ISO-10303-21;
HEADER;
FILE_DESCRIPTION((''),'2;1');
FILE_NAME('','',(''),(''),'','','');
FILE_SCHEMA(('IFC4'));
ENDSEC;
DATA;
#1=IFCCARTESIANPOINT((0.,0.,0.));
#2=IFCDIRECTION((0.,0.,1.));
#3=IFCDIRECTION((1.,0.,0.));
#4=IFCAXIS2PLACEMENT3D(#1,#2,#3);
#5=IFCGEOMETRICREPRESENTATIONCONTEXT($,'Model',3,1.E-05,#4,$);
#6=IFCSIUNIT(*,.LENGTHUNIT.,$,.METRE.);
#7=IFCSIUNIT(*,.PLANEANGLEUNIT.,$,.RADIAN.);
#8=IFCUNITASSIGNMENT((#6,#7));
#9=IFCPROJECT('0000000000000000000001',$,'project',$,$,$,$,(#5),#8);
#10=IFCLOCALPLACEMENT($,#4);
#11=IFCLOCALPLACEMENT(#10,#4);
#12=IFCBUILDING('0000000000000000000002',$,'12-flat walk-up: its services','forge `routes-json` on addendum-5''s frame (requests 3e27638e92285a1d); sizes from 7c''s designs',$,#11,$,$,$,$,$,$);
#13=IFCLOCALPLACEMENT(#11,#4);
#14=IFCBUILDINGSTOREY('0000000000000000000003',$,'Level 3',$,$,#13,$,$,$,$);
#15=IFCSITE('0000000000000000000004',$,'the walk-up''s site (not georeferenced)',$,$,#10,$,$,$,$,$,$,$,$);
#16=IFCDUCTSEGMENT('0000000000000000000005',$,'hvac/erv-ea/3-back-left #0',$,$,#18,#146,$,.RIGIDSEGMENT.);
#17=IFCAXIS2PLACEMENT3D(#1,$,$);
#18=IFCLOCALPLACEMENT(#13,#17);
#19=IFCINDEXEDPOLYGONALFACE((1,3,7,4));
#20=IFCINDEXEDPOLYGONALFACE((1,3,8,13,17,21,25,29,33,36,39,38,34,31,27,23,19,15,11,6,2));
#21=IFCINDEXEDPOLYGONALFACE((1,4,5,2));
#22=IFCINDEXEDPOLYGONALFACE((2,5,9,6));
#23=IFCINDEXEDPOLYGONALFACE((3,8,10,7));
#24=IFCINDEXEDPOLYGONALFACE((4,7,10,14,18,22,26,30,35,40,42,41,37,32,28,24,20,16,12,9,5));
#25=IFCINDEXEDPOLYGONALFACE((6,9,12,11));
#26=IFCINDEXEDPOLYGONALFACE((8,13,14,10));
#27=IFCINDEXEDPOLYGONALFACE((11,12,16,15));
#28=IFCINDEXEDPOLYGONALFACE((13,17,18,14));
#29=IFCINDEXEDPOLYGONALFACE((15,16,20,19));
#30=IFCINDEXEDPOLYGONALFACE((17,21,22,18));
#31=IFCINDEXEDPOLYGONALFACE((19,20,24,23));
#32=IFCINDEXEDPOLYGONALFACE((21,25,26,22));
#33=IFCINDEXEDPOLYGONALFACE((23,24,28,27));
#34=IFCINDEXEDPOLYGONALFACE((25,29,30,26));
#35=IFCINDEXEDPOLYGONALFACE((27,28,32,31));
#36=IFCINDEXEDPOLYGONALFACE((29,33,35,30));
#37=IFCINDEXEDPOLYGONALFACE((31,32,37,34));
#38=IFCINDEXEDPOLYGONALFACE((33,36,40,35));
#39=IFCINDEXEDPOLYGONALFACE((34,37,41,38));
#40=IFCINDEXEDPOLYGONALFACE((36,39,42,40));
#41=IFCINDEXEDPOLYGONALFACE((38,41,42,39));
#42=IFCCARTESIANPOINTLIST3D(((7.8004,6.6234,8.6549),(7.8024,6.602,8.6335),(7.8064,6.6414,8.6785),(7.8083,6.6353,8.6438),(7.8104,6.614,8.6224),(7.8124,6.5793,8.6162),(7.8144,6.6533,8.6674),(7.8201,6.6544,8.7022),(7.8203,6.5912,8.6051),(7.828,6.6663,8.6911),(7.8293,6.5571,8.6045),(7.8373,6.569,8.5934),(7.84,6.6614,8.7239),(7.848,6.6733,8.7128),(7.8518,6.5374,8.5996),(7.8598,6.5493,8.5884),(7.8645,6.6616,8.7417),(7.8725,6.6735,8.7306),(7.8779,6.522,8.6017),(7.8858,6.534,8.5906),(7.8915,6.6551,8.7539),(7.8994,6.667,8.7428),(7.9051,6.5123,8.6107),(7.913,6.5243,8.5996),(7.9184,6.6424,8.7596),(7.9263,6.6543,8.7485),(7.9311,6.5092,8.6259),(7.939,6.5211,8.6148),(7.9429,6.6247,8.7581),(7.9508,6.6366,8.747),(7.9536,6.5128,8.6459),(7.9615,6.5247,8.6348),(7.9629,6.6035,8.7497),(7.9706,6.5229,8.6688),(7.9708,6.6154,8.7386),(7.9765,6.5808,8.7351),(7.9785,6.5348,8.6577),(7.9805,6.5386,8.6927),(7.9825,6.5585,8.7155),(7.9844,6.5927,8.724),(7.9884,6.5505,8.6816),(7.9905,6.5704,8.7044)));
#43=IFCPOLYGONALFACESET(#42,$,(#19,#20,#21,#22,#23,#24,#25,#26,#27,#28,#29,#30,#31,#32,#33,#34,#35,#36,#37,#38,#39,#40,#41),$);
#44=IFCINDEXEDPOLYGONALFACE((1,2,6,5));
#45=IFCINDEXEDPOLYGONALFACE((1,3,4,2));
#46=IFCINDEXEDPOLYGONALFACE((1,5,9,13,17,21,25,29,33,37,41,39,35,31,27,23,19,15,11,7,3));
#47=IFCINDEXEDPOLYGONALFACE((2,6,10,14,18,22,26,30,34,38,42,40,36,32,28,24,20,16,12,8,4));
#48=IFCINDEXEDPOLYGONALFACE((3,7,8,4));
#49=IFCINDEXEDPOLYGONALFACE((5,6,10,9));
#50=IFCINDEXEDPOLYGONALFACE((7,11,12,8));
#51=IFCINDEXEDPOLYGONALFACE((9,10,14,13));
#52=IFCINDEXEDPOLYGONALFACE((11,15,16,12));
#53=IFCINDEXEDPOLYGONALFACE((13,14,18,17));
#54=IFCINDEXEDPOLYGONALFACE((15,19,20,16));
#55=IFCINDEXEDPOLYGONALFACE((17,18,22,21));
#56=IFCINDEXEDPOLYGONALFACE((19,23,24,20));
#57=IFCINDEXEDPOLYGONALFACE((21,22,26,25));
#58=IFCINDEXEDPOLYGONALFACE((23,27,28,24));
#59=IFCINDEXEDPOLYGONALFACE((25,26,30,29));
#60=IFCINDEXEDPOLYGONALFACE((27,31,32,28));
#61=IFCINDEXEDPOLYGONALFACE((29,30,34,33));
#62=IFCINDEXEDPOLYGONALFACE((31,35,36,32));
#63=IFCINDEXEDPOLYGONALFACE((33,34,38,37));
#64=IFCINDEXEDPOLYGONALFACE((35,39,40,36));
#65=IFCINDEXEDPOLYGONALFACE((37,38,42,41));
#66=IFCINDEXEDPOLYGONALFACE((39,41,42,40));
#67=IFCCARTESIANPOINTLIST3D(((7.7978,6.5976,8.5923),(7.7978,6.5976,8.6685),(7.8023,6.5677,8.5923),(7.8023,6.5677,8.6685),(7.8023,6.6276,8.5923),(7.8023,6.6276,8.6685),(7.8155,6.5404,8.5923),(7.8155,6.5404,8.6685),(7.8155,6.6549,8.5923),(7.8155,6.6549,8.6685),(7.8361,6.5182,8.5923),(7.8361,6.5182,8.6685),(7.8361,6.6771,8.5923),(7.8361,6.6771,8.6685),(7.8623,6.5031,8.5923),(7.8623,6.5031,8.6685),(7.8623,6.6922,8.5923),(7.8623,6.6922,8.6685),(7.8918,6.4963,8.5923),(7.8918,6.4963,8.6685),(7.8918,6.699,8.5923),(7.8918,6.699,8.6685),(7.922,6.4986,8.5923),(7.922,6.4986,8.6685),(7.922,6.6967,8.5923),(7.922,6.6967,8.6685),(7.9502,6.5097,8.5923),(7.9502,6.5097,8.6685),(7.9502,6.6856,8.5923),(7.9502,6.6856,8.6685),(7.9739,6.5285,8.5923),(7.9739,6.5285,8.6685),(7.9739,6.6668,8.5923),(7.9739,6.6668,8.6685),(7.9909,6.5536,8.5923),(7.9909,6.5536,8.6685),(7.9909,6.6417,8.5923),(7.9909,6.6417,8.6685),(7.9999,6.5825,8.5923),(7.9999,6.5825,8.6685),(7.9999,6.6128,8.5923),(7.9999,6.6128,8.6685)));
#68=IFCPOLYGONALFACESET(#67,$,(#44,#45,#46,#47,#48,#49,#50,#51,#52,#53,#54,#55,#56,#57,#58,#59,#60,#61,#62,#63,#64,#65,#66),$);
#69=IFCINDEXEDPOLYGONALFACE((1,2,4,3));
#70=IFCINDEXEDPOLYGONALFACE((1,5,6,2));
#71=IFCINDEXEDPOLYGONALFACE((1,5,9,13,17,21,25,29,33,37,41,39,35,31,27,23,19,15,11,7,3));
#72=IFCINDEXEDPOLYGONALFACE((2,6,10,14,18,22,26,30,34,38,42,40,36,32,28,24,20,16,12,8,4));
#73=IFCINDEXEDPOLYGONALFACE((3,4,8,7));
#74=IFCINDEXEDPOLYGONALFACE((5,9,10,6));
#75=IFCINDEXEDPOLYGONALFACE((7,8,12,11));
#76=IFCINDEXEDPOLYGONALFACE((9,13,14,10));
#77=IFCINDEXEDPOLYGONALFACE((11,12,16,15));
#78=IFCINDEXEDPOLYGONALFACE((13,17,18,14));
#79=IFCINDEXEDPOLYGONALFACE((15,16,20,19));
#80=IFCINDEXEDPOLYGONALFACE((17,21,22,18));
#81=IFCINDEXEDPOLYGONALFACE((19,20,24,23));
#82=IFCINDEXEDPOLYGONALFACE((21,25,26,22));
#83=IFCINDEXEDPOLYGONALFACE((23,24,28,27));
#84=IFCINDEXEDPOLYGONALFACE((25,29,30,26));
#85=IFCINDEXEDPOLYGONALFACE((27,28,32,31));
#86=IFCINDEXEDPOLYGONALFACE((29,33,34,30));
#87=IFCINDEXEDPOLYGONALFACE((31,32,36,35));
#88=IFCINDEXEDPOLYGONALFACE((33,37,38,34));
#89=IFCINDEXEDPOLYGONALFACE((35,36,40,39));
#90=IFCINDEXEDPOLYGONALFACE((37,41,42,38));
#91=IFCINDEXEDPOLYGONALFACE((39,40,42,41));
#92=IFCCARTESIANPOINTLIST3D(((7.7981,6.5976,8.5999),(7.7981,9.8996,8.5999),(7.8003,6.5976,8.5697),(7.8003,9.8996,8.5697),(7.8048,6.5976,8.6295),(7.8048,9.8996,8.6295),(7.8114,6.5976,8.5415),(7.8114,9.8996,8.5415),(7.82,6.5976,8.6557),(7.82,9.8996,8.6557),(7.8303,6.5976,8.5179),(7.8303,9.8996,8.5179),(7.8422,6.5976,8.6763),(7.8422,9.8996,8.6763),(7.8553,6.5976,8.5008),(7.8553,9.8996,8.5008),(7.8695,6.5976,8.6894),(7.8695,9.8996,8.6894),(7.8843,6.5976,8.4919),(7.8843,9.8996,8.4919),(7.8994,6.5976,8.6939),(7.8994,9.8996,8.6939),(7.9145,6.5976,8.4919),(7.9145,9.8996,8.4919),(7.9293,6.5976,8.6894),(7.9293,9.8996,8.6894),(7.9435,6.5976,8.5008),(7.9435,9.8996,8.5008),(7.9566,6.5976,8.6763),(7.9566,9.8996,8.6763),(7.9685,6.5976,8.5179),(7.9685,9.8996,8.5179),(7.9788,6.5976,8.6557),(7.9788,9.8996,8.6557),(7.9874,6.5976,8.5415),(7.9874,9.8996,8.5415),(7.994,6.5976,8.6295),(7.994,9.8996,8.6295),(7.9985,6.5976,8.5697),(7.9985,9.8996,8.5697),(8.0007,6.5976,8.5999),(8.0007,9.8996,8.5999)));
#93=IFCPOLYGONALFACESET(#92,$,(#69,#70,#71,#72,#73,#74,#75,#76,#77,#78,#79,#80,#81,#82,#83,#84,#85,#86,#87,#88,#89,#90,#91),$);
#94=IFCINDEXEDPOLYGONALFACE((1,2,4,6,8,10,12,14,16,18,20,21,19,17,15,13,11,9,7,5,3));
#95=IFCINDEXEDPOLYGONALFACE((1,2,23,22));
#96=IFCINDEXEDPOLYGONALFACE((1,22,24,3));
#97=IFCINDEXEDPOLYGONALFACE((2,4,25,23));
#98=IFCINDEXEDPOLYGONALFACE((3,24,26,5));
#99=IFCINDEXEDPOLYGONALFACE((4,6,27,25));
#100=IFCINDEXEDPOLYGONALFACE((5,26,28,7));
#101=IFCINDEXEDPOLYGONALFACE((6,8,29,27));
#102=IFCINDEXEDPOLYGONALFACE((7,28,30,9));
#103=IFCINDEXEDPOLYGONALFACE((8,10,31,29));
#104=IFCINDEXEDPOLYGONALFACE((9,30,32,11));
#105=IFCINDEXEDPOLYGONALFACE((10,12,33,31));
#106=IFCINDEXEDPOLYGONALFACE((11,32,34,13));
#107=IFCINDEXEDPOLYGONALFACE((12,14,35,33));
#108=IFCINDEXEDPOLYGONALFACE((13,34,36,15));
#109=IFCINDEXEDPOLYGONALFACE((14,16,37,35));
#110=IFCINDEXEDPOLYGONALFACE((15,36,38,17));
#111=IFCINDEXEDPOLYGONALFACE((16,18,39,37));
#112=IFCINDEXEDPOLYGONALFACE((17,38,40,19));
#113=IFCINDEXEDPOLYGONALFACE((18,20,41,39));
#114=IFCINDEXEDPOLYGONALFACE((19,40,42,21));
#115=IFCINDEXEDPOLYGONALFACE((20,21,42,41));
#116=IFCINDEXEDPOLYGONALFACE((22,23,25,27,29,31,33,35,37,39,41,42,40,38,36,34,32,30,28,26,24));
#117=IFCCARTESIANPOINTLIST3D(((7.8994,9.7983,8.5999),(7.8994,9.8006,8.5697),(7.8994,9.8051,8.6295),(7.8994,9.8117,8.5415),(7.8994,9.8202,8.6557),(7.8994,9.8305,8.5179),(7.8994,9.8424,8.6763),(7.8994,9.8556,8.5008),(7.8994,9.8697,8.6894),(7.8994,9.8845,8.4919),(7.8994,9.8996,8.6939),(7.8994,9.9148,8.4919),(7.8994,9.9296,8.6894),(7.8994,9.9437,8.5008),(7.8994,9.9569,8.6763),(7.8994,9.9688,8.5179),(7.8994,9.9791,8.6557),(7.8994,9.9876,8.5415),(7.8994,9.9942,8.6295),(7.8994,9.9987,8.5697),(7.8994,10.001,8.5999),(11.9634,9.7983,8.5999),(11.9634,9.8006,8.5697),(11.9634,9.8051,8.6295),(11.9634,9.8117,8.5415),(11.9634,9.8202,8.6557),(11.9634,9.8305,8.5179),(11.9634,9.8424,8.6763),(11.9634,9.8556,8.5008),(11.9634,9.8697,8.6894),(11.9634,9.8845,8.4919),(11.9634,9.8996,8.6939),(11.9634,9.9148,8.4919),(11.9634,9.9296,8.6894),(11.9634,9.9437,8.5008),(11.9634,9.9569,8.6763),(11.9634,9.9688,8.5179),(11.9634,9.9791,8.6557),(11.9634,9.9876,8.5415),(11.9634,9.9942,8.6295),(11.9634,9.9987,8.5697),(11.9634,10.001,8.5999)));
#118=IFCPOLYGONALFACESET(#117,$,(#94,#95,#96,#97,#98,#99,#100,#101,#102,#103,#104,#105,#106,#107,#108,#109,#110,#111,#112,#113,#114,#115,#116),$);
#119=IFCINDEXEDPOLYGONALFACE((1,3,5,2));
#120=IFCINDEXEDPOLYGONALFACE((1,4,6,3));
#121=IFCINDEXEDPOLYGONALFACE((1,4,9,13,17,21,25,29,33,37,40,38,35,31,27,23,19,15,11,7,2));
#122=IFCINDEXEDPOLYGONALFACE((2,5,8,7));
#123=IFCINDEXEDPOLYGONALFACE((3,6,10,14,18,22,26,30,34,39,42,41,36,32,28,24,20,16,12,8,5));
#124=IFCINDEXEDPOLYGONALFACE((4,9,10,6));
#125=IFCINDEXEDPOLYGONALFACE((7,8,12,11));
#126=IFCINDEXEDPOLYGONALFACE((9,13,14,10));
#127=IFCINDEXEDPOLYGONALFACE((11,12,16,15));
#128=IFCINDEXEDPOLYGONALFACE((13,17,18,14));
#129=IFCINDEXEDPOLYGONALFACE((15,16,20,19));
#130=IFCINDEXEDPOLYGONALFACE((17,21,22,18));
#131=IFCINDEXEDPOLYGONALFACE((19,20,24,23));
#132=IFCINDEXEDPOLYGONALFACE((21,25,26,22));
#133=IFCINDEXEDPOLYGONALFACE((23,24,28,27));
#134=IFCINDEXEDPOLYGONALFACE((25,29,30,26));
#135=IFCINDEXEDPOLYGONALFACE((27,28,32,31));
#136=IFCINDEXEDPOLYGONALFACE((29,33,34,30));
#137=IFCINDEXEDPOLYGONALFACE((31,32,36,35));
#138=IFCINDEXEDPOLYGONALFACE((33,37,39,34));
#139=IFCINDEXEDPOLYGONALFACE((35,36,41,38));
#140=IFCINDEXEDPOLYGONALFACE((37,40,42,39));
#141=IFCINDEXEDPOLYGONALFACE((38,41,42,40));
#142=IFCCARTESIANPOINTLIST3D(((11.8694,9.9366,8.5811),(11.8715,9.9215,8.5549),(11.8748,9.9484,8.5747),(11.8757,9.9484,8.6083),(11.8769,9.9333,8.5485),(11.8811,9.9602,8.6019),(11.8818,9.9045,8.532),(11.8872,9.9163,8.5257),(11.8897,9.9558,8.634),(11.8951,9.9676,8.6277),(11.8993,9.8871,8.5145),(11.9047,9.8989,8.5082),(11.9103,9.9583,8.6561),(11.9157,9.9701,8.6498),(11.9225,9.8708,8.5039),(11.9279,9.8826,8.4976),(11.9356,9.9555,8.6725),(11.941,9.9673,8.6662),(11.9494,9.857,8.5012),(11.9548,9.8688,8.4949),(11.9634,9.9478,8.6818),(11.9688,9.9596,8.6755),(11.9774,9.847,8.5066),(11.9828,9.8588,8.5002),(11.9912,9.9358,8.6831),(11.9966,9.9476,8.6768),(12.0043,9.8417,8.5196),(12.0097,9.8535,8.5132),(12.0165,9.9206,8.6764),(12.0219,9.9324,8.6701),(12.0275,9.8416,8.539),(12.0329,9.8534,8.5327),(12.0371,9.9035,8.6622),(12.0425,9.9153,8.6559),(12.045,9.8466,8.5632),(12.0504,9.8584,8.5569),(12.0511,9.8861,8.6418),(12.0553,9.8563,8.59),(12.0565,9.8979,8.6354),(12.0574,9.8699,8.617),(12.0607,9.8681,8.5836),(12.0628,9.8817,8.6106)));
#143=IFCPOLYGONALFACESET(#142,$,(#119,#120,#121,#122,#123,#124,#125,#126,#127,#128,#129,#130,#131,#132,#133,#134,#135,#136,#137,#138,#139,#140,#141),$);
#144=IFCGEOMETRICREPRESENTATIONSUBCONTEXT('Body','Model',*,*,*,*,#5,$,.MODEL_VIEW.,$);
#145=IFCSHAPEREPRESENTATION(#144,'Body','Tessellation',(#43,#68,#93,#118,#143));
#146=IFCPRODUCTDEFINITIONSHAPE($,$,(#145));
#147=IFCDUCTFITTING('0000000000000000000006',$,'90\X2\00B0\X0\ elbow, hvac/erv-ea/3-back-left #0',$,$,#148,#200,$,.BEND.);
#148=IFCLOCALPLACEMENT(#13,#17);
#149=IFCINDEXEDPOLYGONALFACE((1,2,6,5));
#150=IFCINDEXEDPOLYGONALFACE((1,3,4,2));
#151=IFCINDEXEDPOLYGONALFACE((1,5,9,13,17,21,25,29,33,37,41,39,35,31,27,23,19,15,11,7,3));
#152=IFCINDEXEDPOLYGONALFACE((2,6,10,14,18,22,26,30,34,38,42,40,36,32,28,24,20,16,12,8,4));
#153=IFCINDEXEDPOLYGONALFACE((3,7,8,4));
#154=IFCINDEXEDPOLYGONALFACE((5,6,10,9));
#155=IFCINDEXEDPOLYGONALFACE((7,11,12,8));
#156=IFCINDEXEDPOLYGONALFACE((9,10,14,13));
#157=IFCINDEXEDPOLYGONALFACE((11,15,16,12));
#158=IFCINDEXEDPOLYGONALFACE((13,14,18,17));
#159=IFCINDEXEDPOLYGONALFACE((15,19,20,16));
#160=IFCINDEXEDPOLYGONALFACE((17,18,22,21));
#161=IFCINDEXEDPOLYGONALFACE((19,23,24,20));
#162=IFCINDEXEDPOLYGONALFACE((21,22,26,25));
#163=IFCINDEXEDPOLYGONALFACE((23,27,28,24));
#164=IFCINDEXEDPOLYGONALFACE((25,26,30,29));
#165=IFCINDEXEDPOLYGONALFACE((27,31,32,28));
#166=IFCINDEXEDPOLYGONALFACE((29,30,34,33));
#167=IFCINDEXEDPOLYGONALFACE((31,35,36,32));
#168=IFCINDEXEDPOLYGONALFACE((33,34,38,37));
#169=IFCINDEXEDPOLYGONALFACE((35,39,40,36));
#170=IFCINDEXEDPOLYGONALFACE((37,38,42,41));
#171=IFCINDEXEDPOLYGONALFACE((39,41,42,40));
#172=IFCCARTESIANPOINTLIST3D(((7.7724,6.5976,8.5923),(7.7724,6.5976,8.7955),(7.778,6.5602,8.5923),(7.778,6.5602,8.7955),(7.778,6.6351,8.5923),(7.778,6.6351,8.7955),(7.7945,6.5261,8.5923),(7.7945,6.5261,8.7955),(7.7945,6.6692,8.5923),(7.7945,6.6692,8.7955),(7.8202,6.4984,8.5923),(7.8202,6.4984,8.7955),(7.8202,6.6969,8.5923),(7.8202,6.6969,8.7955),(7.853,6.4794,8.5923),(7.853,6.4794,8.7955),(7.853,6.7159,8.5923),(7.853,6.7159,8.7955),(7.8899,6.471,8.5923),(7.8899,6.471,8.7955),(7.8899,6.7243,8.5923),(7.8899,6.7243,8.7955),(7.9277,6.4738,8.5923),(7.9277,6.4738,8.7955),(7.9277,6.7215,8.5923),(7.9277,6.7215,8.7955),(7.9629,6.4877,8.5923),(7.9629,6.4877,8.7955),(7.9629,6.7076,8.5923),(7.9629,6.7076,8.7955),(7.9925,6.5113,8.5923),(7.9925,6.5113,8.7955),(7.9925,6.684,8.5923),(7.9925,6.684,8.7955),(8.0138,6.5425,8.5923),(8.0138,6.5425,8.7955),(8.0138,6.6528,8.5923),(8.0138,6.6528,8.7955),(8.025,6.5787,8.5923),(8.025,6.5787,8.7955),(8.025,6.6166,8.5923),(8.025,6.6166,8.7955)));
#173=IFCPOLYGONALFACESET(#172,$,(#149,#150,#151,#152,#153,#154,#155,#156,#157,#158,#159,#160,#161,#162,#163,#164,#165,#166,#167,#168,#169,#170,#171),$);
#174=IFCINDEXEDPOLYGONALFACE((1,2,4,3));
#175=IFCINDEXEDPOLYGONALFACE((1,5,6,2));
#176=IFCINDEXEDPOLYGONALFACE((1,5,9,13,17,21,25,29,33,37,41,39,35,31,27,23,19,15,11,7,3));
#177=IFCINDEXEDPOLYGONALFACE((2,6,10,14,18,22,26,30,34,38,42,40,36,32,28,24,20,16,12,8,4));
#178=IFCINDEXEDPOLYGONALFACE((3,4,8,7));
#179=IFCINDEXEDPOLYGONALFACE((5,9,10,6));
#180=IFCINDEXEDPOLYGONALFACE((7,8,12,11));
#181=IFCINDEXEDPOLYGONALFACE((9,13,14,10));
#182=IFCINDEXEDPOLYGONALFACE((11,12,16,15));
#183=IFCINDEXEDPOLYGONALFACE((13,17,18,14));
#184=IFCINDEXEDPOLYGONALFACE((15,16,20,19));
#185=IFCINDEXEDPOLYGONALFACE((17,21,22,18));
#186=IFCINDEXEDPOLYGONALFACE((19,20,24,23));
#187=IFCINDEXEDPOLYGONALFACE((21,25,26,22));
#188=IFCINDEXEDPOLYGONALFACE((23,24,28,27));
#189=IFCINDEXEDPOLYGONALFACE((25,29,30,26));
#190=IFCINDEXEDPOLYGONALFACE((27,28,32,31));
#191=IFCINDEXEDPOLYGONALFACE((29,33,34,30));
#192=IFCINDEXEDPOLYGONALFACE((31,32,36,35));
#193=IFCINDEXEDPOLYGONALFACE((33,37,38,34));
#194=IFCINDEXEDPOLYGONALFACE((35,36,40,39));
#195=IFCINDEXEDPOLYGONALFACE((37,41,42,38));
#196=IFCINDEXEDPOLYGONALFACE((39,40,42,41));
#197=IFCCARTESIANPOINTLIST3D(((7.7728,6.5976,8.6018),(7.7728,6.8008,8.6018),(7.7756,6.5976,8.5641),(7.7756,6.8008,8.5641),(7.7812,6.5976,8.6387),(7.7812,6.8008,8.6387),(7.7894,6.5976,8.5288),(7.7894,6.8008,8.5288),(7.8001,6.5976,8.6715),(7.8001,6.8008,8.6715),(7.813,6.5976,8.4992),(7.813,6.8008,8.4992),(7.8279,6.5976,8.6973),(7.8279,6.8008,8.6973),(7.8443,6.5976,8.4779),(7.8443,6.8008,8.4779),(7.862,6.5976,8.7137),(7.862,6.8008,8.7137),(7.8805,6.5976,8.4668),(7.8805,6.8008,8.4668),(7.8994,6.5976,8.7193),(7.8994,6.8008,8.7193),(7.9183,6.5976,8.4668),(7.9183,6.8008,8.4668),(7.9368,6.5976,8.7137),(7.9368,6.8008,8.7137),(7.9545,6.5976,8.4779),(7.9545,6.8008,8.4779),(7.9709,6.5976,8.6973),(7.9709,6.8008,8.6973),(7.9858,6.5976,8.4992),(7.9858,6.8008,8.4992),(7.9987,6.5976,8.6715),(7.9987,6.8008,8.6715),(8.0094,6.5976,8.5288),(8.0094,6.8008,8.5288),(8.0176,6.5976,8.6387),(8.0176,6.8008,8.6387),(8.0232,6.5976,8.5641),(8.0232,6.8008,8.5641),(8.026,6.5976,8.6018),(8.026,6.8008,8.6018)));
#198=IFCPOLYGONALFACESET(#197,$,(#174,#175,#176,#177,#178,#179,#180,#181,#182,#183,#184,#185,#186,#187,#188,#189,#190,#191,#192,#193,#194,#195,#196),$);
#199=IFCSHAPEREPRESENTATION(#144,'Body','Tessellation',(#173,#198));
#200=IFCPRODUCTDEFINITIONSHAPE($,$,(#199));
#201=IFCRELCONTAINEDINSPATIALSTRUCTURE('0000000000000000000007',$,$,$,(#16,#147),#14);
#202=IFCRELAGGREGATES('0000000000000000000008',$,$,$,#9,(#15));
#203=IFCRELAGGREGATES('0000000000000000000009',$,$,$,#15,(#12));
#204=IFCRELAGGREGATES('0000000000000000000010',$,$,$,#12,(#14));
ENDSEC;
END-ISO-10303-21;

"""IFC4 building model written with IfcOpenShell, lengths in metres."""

from ifc_helpers import new_model, entity, si_unit, frame, origin_with_axes, place, context, subcontext, project, spatial, element, save


model = new_model("IFC4")

# Units and contexts
model_context = context("Model", 3, precision=1e-05, world=origin_with_axes())
body_context = subcontext(model_context, "Body", "Model", "MODEL_VIEW")
ifc_project = project(units=[si_unit("LENGTHUNIT", "METRE"), si_unit("PLANEANGLEUNIT", "RADIAN")], contexts=[model_context])

# Site, building, storey
site_placement = place(None, origin_with_axes())
site = spatial("IfcSite", under=ifc_project, at=site_placement, Name="the walk-up's site (not georeferenced)")
building_placement = place(site_placement, origin_with_axes())
building = spatial("IfcBuilding", under=site, at=building_placement, Name="12-flat walk-up: its services", Description="forge `routes-json` on addendum-5's frame (requests 3e27638e92285a1d); sizes from 7c's designs")
storey_placement = place(building_placement, origin_with_axes())
storey = spatial("IfcBuildingStorey", under=building, at=storey_placement, Name="Level 3")

# Duct segment
duct_segment_1_placement = place(storey_placement, frame((7.8915, 6.5857, 8.6797), z_axis=(0.0, 0.0, 1.0), x_axis=(1.0, 0.0, 0.0)))
element("IfcDuctSegment", 1, at=duct_segment_1_placement, inside=storey, Name="hvac/erv-ea/3-back-left #0", PredefinedType="RIGIDSEGMENT", context=body_context, shape_type="AdvancedSweptSolid", body=[
    entity("IfcSweptDiskSolid", entity("IfcPolyline", [entity("IfcCartesianPoint", [0.0, 0.0, 0.0]), entity("IfcCartesianPoint", [0.0079, 0.0119, -0.0111])]), 0.1016),
    entity("IfcSweptDiskSolid", entity("IfcPolyline", [entity("IfcCartesianPoint", [0.0079, 0.0119, -0.0111]), entity("IfcCartesianPoint", [0.0079, 0.0119, -0.0873])]), 0.1016),
    entity("IfcSweptDiskSolid", entity("IfcPolyline", [entity("IfcCartesianPoint", [0.0079, 0.0119, -0.0873]), entity("IfcCartesianPoint", [0.0079, 3.3139, -0.0873])]), 0.1016),
    entity("IfcSweptDiskSolid", entity("IfcPolyline", [entity("IfcCartesianPoint", [0.0079, 3.3139, -0.0873]), entity("IfcCartesianPoint", [4.0719, 3.3139, -0.0873])]), 0.1016),
    entity("IfcSweptDiskSolid", entity("IfcPolyline", [entity("IfcCartesianPoint", [4.0719, 3.3139, -0.0873]), entity("IfcCartesianPoint", [4.0773, 3.3257, -0.0937])]), 0.1016),
])

# Duct fitting
duct_fitting_1_placement = place(storey_placement, frame((7.8994, 6.5976, 8.7955), z_axis=(0.0, 0.0, 1.0), x_axis=(1.0, 0.0, 0.0)))
element("IfcDuctFitting", 2, at=duct_fitting_1_placement, inside=storey, Name="90° elbow, hvac/erv-ea/3-back-left #0", PredefinedType="BEND", context=body_context, shape_type="AdvancedSweptSolid", body=[
    entity("IfcSweptDiskSolid", entity("IfcPolyline", [entity("IfcCartesianPoint", [0.0, 0.0, 0.0]), entity("IfcCartesianPoint", [0.0, 0.0, -0.2032])]), 0.127),
    entity("IfcSweptDiskSolid", entity("IfcPolyline", [entity("IfcCartesianPoint", [0.0, 0.0, -0.2032]), entity("IfcCartesianPoint", [0.0, 0.2032, -0.2032])]), 0.127),
])

save(model, "model.ifc")
